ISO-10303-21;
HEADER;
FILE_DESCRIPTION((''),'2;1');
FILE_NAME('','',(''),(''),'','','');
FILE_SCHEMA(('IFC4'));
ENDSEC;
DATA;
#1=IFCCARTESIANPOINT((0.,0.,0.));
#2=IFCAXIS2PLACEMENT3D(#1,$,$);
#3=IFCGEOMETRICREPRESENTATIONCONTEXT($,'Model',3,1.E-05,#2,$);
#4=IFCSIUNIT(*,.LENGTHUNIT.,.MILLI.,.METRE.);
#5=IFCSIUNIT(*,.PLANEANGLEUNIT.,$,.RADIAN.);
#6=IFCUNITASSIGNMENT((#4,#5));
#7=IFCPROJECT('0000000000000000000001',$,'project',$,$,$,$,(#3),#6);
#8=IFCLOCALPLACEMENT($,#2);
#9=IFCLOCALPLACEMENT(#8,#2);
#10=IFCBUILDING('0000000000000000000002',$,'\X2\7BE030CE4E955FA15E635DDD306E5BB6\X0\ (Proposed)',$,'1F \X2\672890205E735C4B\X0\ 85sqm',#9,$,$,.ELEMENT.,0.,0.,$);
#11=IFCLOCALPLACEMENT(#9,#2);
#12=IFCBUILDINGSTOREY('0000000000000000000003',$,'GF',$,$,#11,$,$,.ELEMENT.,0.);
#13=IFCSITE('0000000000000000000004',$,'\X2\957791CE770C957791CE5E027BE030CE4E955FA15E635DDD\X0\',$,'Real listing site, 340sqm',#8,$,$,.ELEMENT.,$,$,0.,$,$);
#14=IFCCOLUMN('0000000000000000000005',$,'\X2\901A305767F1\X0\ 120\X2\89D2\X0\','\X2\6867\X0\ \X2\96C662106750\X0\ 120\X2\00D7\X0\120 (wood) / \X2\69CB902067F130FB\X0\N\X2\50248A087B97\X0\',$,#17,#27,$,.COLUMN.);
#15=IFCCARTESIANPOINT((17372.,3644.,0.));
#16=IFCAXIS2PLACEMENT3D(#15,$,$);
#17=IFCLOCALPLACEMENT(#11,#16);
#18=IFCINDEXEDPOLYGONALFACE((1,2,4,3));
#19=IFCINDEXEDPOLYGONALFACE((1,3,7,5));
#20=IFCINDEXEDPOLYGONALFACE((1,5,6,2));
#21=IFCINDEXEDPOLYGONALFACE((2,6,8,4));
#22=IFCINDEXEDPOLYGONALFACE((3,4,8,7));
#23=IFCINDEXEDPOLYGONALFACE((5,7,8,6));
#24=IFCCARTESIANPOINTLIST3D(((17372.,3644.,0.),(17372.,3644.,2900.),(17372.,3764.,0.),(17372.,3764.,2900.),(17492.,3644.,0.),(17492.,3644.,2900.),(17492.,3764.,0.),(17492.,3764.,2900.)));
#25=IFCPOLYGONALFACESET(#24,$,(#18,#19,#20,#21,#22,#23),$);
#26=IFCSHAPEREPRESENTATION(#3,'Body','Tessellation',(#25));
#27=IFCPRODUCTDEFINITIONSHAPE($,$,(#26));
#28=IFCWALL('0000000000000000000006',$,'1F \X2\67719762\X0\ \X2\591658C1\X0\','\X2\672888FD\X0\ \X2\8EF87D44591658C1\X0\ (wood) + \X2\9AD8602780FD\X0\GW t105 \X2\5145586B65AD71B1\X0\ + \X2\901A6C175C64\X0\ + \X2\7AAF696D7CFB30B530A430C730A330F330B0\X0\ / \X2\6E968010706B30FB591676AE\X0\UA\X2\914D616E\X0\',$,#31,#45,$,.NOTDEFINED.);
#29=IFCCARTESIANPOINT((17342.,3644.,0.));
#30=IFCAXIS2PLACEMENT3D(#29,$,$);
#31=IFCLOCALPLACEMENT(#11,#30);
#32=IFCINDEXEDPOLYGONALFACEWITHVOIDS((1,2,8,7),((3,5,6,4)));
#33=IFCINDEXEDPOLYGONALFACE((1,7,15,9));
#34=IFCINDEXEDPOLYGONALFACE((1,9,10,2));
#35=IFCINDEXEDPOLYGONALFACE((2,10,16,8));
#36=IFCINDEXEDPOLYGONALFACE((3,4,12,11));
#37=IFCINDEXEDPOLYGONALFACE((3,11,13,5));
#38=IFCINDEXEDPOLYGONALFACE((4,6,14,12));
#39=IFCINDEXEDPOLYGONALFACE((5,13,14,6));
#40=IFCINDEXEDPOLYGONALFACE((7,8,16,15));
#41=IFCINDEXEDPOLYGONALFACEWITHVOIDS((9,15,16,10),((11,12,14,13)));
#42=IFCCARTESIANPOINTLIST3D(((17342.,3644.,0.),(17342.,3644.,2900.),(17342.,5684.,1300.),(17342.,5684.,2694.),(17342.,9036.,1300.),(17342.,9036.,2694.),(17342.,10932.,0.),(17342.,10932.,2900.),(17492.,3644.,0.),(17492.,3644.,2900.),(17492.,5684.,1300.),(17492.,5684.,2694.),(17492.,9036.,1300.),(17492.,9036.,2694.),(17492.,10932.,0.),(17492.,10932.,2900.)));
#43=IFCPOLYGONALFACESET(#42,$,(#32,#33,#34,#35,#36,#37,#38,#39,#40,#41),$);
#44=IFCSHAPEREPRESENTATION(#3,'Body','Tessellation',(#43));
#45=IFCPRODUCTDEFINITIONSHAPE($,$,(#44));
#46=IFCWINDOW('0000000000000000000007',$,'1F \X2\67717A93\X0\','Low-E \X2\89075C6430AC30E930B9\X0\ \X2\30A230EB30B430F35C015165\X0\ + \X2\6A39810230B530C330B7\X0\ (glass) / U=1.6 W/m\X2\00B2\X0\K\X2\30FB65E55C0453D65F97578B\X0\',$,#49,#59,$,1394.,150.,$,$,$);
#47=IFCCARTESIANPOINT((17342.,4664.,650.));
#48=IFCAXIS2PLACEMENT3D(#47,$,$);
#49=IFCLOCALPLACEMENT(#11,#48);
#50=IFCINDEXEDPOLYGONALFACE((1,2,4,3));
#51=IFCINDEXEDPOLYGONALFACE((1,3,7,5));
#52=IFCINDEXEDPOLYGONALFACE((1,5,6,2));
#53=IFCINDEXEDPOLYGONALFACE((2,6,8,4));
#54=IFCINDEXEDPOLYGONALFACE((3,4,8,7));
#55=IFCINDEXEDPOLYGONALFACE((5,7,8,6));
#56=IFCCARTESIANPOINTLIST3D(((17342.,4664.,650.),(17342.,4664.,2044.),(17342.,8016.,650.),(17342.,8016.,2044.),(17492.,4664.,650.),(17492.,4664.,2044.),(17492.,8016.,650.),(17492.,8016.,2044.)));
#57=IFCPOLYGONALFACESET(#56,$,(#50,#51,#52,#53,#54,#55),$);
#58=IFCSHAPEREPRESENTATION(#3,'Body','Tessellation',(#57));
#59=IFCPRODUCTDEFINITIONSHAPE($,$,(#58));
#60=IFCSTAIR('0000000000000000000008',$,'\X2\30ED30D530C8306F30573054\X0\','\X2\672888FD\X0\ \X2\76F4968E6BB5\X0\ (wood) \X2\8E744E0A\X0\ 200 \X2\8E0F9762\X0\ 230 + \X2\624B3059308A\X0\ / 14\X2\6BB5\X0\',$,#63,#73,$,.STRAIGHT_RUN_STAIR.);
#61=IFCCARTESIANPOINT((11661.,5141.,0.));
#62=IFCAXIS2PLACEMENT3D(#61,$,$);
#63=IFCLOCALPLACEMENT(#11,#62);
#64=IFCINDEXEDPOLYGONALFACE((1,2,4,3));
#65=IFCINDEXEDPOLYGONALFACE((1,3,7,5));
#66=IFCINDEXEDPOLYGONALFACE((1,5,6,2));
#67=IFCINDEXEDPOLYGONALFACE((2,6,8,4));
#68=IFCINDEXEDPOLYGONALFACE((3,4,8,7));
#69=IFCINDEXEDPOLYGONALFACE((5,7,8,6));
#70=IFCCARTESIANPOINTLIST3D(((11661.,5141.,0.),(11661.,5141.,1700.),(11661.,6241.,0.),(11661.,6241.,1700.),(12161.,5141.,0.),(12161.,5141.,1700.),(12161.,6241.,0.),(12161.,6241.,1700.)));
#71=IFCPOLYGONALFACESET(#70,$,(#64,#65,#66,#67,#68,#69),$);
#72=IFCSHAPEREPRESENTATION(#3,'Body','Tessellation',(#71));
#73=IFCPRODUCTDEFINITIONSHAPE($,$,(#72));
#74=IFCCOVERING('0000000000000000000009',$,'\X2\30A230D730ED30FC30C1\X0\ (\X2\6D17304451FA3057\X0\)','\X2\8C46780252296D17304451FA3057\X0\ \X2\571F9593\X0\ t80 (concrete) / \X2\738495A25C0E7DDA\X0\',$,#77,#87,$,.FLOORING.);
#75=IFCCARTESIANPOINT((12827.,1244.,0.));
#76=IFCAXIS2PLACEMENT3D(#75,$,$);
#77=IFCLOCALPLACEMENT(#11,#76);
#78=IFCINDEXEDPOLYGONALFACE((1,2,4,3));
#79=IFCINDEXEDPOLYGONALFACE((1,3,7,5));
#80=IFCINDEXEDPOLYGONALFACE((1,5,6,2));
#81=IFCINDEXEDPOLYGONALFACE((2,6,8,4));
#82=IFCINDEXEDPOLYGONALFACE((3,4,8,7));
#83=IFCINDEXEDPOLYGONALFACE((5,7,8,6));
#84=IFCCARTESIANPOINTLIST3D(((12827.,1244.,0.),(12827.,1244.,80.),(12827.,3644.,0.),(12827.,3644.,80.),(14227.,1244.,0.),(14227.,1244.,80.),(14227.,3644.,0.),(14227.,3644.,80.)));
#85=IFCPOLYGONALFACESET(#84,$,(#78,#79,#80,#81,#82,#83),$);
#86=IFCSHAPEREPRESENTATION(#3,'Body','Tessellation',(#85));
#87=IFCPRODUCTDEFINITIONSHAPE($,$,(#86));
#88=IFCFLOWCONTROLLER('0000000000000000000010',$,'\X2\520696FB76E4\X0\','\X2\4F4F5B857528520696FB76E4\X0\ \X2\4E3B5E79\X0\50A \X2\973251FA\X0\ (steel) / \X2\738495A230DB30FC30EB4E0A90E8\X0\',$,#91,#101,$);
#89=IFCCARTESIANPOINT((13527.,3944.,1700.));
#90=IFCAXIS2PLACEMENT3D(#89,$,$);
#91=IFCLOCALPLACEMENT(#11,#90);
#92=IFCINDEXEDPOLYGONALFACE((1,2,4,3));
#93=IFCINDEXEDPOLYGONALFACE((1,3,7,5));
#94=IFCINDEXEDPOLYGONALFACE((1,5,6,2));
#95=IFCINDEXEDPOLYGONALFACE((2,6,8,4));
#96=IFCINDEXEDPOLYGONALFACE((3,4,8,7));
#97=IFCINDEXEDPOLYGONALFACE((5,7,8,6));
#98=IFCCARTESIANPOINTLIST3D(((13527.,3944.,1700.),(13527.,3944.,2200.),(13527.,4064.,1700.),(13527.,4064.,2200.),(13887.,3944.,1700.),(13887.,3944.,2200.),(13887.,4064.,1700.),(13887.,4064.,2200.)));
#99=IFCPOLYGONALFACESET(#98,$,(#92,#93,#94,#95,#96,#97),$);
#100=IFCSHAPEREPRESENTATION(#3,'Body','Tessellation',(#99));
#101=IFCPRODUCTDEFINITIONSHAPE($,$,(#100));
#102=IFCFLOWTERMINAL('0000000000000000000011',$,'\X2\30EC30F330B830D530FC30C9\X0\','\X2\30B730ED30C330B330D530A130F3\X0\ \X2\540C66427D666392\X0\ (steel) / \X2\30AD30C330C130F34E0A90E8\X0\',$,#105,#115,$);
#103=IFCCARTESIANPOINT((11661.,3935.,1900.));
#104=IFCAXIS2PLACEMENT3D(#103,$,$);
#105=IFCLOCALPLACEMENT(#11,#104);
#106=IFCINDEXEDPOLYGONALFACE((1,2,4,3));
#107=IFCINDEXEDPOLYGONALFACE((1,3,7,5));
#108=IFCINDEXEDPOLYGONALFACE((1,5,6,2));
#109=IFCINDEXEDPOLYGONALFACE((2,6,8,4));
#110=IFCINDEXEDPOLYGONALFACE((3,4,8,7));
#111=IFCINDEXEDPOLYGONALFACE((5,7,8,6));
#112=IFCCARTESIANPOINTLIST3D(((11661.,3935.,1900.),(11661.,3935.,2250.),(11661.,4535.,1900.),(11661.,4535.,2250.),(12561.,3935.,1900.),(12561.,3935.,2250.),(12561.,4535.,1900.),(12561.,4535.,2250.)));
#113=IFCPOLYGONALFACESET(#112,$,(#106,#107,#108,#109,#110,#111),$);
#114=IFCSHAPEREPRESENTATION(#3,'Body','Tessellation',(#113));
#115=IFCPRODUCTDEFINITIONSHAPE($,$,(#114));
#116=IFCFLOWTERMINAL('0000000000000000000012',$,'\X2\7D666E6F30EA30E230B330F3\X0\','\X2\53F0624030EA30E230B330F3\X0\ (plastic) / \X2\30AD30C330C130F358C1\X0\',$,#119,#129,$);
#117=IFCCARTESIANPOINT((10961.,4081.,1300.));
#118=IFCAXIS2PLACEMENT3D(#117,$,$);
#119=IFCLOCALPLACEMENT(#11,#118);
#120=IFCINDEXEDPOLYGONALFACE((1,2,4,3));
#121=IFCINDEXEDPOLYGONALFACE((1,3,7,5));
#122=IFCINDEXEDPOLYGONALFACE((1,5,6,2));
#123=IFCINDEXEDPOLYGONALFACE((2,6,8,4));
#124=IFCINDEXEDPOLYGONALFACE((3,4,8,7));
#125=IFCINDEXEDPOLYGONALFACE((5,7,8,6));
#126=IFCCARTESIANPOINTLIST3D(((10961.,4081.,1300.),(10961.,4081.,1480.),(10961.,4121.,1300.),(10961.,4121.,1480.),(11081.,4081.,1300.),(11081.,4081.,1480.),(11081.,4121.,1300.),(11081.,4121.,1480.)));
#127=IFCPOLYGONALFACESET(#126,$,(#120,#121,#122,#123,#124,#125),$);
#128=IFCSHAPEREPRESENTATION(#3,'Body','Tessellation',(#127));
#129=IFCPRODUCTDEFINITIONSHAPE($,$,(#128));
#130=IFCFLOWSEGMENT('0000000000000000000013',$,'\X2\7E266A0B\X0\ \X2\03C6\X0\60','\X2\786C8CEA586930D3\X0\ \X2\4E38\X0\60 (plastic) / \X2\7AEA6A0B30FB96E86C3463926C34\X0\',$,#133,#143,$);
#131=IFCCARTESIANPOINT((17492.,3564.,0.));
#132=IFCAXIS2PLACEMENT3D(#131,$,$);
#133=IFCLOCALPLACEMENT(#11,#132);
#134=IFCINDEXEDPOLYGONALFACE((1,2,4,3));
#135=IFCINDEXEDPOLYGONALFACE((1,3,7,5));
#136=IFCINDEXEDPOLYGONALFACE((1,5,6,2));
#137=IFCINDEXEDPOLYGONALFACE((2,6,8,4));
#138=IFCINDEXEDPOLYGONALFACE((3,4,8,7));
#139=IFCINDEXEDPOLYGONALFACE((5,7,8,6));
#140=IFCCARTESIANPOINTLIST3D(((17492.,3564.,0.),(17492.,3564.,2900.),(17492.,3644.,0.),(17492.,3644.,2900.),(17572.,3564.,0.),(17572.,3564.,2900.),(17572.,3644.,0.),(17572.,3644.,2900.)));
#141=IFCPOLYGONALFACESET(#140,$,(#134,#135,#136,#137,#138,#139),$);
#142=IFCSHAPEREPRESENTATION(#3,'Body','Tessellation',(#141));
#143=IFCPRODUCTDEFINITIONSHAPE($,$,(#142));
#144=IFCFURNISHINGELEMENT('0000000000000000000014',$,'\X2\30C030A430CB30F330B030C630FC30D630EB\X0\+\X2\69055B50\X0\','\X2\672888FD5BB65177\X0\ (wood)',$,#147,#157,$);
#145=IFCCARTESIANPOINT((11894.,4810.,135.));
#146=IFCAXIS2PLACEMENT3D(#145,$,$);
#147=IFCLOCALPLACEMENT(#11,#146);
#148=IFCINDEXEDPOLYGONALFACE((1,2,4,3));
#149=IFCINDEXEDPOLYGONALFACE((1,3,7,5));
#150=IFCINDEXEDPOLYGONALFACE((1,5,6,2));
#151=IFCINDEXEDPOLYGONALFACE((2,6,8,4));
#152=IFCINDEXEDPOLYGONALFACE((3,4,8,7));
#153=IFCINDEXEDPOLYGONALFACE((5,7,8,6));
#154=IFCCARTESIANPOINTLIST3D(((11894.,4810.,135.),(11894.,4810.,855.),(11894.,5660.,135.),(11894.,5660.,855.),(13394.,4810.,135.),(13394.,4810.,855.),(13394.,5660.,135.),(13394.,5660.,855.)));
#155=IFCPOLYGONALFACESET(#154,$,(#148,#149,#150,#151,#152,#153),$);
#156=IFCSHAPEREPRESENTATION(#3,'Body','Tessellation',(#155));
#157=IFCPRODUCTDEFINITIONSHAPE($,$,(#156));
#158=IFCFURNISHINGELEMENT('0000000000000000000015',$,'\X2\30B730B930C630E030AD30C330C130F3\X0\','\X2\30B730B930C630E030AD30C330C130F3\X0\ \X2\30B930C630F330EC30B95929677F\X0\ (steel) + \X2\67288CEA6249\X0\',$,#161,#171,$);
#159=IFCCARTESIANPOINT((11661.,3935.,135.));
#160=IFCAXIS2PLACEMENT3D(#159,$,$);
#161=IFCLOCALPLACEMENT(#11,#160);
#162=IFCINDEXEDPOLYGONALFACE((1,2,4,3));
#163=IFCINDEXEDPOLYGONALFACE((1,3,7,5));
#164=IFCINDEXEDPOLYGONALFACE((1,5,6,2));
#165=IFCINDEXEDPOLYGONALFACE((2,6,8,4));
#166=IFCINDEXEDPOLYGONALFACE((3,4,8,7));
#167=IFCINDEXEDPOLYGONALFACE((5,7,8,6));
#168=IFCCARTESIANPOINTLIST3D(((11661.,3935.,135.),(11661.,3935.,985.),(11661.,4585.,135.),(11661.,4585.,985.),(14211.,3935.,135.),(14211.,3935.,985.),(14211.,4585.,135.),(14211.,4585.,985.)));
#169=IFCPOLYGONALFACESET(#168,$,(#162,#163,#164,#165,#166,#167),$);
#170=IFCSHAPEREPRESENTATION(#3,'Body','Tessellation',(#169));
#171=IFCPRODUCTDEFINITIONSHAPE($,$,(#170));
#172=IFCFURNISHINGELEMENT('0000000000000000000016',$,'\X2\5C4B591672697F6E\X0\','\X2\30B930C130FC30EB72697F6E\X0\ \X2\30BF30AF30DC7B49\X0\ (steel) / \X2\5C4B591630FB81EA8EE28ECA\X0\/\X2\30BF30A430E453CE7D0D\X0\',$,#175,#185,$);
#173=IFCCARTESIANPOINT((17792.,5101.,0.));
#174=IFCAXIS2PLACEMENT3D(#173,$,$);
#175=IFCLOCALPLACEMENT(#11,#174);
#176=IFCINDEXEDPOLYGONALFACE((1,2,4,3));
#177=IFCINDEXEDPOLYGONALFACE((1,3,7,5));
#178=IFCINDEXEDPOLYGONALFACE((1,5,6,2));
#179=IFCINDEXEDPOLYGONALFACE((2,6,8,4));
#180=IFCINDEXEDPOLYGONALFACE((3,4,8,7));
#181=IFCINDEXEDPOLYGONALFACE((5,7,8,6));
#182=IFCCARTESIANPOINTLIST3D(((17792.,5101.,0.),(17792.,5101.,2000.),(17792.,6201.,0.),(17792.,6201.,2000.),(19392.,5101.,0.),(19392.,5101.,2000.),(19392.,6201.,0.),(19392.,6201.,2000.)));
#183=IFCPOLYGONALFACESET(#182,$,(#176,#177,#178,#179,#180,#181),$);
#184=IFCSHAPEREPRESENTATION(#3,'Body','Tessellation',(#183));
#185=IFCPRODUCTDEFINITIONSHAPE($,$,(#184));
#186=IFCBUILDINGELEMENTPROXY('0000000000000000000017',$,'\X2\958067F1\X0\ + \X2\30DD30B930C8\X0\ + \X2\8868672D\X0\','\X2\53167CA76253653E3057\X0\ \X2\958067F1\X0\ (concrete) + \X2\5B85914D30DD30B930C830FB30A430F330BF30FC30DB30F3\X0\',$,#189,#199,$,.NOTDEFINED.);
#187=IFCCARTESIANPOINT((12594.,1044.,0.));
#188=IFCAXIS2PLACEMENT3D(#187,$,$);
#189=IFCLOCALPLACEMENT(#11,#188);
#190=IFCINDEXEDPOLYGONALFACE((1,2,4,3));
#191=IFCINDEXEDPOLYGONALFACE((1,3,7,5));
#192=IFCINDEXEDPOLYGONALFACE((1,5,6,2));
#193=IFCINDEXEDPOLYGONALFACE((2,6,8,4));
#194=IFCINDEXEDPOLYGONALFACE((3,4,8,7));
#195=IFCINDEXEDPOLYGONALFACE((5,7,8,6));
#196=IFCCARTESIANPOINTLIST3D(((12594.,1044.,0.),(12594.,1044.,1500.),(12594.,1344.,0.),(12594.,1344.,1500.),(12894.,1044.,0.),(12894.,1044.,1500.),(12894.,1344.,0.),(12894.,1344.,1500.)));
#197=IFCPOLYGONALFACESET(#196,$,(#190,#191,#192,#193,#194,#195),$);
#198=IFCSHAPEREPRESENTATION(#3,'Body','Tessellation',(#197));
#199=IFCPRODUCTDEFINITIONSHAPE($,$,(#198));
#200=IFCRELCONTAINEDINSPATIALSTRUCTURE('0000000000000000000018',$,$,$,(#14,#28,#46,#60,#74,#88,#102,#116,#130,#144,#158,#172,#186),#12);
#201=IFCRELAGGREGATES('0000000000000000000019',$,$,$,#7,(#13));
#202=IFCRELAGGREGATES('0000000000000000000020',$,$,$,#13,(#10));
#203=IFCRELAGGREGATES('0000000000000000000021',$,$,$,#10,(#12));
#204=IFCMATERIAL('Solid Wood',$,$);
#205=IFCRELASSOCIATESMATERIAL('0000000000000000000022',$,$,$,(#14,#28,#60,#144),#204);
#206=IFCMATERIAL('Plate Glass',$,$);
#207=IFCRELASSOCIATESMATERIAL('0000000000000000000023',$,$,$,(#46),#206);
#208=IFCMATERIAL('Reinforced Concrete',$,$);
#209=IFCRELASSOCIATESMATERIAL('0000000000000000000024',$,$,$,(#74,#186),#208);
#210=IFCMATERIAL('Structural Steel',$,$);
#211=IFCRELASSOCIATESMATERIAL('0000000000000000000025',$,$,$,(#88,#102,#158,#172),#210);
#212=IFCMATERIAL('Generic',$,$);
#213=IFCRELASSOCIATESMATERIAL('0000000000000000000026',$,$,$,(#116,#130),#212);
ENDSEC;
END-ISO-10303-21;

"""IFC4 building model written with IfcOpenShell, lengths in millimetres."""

from ifc_helpers import new_model, si_unit, frame, frame_2d, origin, place, context, project, spatial, rectangle, extrude, material, element, fill, save


model = new_model("IFC4")

# Units and contexts
model_context = context("Model", 3, precision=1e-05, world=origin())
ifc_project = project(units=[si_unit("LENGTHUNIT", "METRE", prefix="MILLI"), si_unit("PLANEANGLEUNIT", "RADIAN")], contexts=[model_context])

# Site, building, storey
site_placement = place(None, origin())
site = spatial("IfcSite", under=ifc_project, at=site_placement, Name="長野県長野市篠ノ井御幣川", ObjectType="Real listing site, 340sqm", CompositionType="ELEMENT", RefElevation=0.0)
building_placement = place(site_placement, origin())
building = spatial("IfcBuilding", under=site, at=building_placement, Name="篠ノ井御幣川の家 (Proposed)", ObjectType="1F 木造平屋 85sqm", CompositionType="ELEMENT", ElevationOfRefHeight=0.0, ElevationOfTerrain=0.0)
storey_placement = place(building_placement, origin())
storey = spatial("IfcBuildingStorey", under=building, at=storey_placement, Name="GF", CompositionType="ELEMENT", Elevation=0.0)

# Column
ifc_material_1 = material(Name="Solid Wood")
column_1_placement = place(storey_placement, frame((17372.0, 3644.0, 0.0)))
element("IfcColumn", 1, at=column_1_placement, inside=storey, material=ifc_material_1, Name="通し柱 120角", Description="桧 集成材 120×120 (wood) / 構造柱・N値計算", PredefinedType="COLUMN", context=model_context, shape_type="SweptSolid", body=[
    extrude(rectangle(XDim=120.0, YDim=120.0, at=frame_2d((60.0, 60.0))), frame((17372.0, 3644.0, 0.0)), (0.0, 0.0, 1.0), 2900.0),
])

# Wall, opening, window
wall_1_placement = place(storey_placement, frame((17342.0, 3644.0, 0.0)))
wall_1 = element("IfcWall", 2, at=wall_1_placement, inside=storey, material=ifc_material_1, Name="1F 東面 外壁", Description="木製 軸組外壁 (wood) + 高性能GW t105 充填断熱 + 通気層 + 窯業系サイディング / 準耐火・外皮UA配慮", PredefinedType="NOTDEFINED", context=model_context, shape_type="SweptSolid", body=[
    extrude(rectangle(XDim=150.0, YDim=7288.0, at=frame_2d((75.0, 3644.0))), frame((17342.0, 3644.0, 0.0)), (0.0, 0.0, 1.0), 2900.0),
])
opening_placement = place(storey_placement, frame((17342.0, 4664.0, 650.0)))
opening = element("IfcOpeningElement", 3, at=opening_placement, cuts=wall_1, PredefinedType="NOTDEFINED", context=model_context, shape_type="SweptSolid", body=[
    extrude(rectangle(XDim=150.0, YDim=3352.0, at=frame_2d((75.0, 1676.0))), frame((17342.0, 4664.0, 650.0)), (0.0, 0.0, 1.0), 1394.0),
])
ifc_material_2 = material(Name="Plate Glass")
window_placement = place(storey_placement, frame((17342.0, 4664.0, 650.0)))
window = element("IfcWindow", 4, at=window_placement, inside=storey, material=ifc_material_2, Name="1F 東窓", Description="Low-E 複層ガラス アルゴン封入 + 樹脂サッシ (glass) / U=1.6 W/m²K・日射取得型", OverallHeight=1394.0, OverallWidth=150.0, context=model_context, shape_type="SweptSolid", body=[
    extrude(rectangle(XDim=150.0, YDim=3352.0, at=frame_2d((75.0, 1676.0))), frame((17342.0, 4664.0, 650.0)), (0.0, 0.0, 1.0), 1394.0),
])
fill(opening, window)

# Stair
stair_placement = place(storey_placement, frame((11661.0, 5141.0, 0.0)))
element("IfcStair", 5, at=stair_placement, inside=storey, material=ifc_material_1, Name="ロフトはしご", Description="木製 直階段 (wood) 蹴上 200 踏面 230 + 手すり / 14段", PredefinedType="STRAIGHT_RUN_STAIR", context=model_context, shape_type="SweptSolid", body=[
    extrude(rectangle(XDim=500.0, YDim=1100.0, at=frame_2d((250.0, 550.0))), frame((11661.0, 5141.0, 0.0)), (0.0, 0.0, 1.0), 1700.0),
])

# Covering
ifc_material_3 = material(Name="Reinforced Concrete")
covering_placement = place(storey_placement, frame((12827.0, 1244.0, 0.0)))
element("IfcCovering", 6, at=covering_placement, inside=storey, material=ifc_material_3, Name="アプローチ (洗い出し)", Description="豆砂利洗い出し 土間 t80 (concrete) / 玄関導線", PredefinedType="FLOORING", context=model_context, shape_type="SweptSolid", body=[
    extrude(rectangle(XDim=1400.0, YDim=2400.0, at=frame_2d((700.0, 1200.0))), frame((12827.0, 1244.0, 0.0)), (0.0, 0.0, 1.0), 80.0),
])

# Flow controller
ifc_material_4 = material(Name="Structural Steel")
flow_controller_placement = place(storey_placement, frame((13527.0, 3944.0, 1700.0)))
element("IfcFlowController", 7, at=flow_controller_placement, inside=storey, material=ifc_material_4, Name="分電盤", Description="住宅用分電盤 主幹50A 露出 (steel) / 玄関ホール上部", context=model_context, shape_type="SweptSolid", body=[
    extrude(rectangle(XDim=360.0, YDim=120.0, at=frame_2d((180.0, 60.0))), frame((13527.0, 3944.0, 1700.0)), (0.0, 0.0, 1.0), 500.0),
])

# Flow terminals
flow_terminal_1_placement = place(storey_placement, frame((11661.0, 3935.0, 1900.0)))
element("IfcFlowTerminal", 8, at=flow_terminal_1_placement, inside=storey, material=ifc_material_4, Name="レンジフード", Description="シロッコファン 同時給排 (steel) / キッチン上部", context=model_context, shape_type="SweptSolid", body=[
    extrude(rectangle(XDim=900.0, YDim=600.0, at=frame_2d((450.0, 300.0))), frame((11661.0, 3935.0, 1900.0)), (0.0, 0.0, 1.0), 350.0),
])
ifc_material_5 = material(Name="Generic")
flow_terminal_2_placement = place(storey_placement, frame((10961.0, 4081.0, 1300.0)))
element("IfcFlowTerminal", 9, at=flow_terminal_2_placement, inside=storey, material=ifc_material_5, Name="給湯リモコン", Description="台所リモコン (plastic) / キッチン壁", context=model_context, shape_type="SweptSolid", body=[
    extrude(rectangle(XDim=120.0, YDim=40.0, at=frame_2d((60.0, 20.0))), frame((10961.0, 4081.0, 1300.0)), (0.0, 0.0, 1.0), 180.0),
])

# Flow segment
flow_segment_placement = place(storey_placement, frame((17492.0, 3564.0, 0.0)))
element("IfcFlowSegment", 10, at=flow_segment_placement, inside=storey, material=ifc_material_5, Name="縦樋 φ60", Description="硬質塩ビ 丸60 (plastic) / 竪樋・雨水排水", context=model_context, shape_type="SweptSolid", body=[
    extrude(rectangle(XDim=80.0, YDim=80.0, at=frame_2d((40.0, 40.0))), frame((17492.0, 3564.0, 0.0)), (0.0, 0.0, 1.0), 2900.0),
])

# Furnishing elements
furnishing_1_placement = place(storey_placement, frame((11894.0, 4810.0, 135.0)))
element("IfcFurnishingElement", 11, at=furnishing_1_placement, inside=storey, material=ifc_material_1, Name="ダイニングテーブル+椅子", Description="木製家具 (wood)", context=model_context, shape_type="SweptSolid", body=[
    extrude(rectangle(XDim=1500.0, YDim=850.0, at=frame_2d((750.0, 425.0))), frame((11894.0, 4810.0, 135.0)), (0.0, 0.0, 1.0), 720.0),
])
furnishing_2_placement = place(storey_placement, frame((11661.0, 3935.0, 135.0)))
element("IfcFurnishingElement", 12, at=furnishing_2_placement, inside=storey, material=ifc_material_4, Name="システムキッチン", Description="システムキッチン ステンレス天板 (steel) + 木質扉", context=model_context, shape_type="SweptSolid", body=[
    extrude(rectangle(XDim=2550.0, YDim=650.0, at=frame_2d((1275.0, 325.0))), frame((11661.0, 3935.0, 135.0)), (0.0, 0.0, 1.0), 850.0),
])
furnishing_3_placement = place(storey_placement, frame((17792.0, 5101.0, 0.0)))
element("IfcFurnishingElement", 13, at=furnishing_3_placement, inside=storey, material=ifc_material_4, Name="屋外物置", Description="スチール物置 タクボ等 (steel) / 屋外・自転車/タイヤ収納", context=model_context, shape_type="SweptSolid", body=[
    extrude(rectangle(XDim=1600.0, YDim=1100.0, at=frame_2d((800.0, 550.0))), frame((17792.0, 5101.0, 0.0)), (0.0, 0.0, 1.0), 2000.0),
])

# Building element proxy
proxy_placement = place(storey_placement, frame((12594.0, 1044.0, 0.0)))
element("IfcBuildingElementProxy", 14, at=proxy_placement, inside=storey, material=ifc_material_3, Name="門柱 + ポスト + 表札", Description="化粧打放し 門柱 (concrete) + 宅配ポスト・インターホン", PredefinedType="NOTDEFINED", context=model_context, shape_type="SweptSolid", body=[
    extrude(rectangle(XDim=300.0, YDim=300.0, at=frame_2d((150.0, 150.0))), frame((12594.0, 1044.0, 0.0)), (0.0, 0.0, 1.0), 1500.0),
])

save(model, "model.ifc")
